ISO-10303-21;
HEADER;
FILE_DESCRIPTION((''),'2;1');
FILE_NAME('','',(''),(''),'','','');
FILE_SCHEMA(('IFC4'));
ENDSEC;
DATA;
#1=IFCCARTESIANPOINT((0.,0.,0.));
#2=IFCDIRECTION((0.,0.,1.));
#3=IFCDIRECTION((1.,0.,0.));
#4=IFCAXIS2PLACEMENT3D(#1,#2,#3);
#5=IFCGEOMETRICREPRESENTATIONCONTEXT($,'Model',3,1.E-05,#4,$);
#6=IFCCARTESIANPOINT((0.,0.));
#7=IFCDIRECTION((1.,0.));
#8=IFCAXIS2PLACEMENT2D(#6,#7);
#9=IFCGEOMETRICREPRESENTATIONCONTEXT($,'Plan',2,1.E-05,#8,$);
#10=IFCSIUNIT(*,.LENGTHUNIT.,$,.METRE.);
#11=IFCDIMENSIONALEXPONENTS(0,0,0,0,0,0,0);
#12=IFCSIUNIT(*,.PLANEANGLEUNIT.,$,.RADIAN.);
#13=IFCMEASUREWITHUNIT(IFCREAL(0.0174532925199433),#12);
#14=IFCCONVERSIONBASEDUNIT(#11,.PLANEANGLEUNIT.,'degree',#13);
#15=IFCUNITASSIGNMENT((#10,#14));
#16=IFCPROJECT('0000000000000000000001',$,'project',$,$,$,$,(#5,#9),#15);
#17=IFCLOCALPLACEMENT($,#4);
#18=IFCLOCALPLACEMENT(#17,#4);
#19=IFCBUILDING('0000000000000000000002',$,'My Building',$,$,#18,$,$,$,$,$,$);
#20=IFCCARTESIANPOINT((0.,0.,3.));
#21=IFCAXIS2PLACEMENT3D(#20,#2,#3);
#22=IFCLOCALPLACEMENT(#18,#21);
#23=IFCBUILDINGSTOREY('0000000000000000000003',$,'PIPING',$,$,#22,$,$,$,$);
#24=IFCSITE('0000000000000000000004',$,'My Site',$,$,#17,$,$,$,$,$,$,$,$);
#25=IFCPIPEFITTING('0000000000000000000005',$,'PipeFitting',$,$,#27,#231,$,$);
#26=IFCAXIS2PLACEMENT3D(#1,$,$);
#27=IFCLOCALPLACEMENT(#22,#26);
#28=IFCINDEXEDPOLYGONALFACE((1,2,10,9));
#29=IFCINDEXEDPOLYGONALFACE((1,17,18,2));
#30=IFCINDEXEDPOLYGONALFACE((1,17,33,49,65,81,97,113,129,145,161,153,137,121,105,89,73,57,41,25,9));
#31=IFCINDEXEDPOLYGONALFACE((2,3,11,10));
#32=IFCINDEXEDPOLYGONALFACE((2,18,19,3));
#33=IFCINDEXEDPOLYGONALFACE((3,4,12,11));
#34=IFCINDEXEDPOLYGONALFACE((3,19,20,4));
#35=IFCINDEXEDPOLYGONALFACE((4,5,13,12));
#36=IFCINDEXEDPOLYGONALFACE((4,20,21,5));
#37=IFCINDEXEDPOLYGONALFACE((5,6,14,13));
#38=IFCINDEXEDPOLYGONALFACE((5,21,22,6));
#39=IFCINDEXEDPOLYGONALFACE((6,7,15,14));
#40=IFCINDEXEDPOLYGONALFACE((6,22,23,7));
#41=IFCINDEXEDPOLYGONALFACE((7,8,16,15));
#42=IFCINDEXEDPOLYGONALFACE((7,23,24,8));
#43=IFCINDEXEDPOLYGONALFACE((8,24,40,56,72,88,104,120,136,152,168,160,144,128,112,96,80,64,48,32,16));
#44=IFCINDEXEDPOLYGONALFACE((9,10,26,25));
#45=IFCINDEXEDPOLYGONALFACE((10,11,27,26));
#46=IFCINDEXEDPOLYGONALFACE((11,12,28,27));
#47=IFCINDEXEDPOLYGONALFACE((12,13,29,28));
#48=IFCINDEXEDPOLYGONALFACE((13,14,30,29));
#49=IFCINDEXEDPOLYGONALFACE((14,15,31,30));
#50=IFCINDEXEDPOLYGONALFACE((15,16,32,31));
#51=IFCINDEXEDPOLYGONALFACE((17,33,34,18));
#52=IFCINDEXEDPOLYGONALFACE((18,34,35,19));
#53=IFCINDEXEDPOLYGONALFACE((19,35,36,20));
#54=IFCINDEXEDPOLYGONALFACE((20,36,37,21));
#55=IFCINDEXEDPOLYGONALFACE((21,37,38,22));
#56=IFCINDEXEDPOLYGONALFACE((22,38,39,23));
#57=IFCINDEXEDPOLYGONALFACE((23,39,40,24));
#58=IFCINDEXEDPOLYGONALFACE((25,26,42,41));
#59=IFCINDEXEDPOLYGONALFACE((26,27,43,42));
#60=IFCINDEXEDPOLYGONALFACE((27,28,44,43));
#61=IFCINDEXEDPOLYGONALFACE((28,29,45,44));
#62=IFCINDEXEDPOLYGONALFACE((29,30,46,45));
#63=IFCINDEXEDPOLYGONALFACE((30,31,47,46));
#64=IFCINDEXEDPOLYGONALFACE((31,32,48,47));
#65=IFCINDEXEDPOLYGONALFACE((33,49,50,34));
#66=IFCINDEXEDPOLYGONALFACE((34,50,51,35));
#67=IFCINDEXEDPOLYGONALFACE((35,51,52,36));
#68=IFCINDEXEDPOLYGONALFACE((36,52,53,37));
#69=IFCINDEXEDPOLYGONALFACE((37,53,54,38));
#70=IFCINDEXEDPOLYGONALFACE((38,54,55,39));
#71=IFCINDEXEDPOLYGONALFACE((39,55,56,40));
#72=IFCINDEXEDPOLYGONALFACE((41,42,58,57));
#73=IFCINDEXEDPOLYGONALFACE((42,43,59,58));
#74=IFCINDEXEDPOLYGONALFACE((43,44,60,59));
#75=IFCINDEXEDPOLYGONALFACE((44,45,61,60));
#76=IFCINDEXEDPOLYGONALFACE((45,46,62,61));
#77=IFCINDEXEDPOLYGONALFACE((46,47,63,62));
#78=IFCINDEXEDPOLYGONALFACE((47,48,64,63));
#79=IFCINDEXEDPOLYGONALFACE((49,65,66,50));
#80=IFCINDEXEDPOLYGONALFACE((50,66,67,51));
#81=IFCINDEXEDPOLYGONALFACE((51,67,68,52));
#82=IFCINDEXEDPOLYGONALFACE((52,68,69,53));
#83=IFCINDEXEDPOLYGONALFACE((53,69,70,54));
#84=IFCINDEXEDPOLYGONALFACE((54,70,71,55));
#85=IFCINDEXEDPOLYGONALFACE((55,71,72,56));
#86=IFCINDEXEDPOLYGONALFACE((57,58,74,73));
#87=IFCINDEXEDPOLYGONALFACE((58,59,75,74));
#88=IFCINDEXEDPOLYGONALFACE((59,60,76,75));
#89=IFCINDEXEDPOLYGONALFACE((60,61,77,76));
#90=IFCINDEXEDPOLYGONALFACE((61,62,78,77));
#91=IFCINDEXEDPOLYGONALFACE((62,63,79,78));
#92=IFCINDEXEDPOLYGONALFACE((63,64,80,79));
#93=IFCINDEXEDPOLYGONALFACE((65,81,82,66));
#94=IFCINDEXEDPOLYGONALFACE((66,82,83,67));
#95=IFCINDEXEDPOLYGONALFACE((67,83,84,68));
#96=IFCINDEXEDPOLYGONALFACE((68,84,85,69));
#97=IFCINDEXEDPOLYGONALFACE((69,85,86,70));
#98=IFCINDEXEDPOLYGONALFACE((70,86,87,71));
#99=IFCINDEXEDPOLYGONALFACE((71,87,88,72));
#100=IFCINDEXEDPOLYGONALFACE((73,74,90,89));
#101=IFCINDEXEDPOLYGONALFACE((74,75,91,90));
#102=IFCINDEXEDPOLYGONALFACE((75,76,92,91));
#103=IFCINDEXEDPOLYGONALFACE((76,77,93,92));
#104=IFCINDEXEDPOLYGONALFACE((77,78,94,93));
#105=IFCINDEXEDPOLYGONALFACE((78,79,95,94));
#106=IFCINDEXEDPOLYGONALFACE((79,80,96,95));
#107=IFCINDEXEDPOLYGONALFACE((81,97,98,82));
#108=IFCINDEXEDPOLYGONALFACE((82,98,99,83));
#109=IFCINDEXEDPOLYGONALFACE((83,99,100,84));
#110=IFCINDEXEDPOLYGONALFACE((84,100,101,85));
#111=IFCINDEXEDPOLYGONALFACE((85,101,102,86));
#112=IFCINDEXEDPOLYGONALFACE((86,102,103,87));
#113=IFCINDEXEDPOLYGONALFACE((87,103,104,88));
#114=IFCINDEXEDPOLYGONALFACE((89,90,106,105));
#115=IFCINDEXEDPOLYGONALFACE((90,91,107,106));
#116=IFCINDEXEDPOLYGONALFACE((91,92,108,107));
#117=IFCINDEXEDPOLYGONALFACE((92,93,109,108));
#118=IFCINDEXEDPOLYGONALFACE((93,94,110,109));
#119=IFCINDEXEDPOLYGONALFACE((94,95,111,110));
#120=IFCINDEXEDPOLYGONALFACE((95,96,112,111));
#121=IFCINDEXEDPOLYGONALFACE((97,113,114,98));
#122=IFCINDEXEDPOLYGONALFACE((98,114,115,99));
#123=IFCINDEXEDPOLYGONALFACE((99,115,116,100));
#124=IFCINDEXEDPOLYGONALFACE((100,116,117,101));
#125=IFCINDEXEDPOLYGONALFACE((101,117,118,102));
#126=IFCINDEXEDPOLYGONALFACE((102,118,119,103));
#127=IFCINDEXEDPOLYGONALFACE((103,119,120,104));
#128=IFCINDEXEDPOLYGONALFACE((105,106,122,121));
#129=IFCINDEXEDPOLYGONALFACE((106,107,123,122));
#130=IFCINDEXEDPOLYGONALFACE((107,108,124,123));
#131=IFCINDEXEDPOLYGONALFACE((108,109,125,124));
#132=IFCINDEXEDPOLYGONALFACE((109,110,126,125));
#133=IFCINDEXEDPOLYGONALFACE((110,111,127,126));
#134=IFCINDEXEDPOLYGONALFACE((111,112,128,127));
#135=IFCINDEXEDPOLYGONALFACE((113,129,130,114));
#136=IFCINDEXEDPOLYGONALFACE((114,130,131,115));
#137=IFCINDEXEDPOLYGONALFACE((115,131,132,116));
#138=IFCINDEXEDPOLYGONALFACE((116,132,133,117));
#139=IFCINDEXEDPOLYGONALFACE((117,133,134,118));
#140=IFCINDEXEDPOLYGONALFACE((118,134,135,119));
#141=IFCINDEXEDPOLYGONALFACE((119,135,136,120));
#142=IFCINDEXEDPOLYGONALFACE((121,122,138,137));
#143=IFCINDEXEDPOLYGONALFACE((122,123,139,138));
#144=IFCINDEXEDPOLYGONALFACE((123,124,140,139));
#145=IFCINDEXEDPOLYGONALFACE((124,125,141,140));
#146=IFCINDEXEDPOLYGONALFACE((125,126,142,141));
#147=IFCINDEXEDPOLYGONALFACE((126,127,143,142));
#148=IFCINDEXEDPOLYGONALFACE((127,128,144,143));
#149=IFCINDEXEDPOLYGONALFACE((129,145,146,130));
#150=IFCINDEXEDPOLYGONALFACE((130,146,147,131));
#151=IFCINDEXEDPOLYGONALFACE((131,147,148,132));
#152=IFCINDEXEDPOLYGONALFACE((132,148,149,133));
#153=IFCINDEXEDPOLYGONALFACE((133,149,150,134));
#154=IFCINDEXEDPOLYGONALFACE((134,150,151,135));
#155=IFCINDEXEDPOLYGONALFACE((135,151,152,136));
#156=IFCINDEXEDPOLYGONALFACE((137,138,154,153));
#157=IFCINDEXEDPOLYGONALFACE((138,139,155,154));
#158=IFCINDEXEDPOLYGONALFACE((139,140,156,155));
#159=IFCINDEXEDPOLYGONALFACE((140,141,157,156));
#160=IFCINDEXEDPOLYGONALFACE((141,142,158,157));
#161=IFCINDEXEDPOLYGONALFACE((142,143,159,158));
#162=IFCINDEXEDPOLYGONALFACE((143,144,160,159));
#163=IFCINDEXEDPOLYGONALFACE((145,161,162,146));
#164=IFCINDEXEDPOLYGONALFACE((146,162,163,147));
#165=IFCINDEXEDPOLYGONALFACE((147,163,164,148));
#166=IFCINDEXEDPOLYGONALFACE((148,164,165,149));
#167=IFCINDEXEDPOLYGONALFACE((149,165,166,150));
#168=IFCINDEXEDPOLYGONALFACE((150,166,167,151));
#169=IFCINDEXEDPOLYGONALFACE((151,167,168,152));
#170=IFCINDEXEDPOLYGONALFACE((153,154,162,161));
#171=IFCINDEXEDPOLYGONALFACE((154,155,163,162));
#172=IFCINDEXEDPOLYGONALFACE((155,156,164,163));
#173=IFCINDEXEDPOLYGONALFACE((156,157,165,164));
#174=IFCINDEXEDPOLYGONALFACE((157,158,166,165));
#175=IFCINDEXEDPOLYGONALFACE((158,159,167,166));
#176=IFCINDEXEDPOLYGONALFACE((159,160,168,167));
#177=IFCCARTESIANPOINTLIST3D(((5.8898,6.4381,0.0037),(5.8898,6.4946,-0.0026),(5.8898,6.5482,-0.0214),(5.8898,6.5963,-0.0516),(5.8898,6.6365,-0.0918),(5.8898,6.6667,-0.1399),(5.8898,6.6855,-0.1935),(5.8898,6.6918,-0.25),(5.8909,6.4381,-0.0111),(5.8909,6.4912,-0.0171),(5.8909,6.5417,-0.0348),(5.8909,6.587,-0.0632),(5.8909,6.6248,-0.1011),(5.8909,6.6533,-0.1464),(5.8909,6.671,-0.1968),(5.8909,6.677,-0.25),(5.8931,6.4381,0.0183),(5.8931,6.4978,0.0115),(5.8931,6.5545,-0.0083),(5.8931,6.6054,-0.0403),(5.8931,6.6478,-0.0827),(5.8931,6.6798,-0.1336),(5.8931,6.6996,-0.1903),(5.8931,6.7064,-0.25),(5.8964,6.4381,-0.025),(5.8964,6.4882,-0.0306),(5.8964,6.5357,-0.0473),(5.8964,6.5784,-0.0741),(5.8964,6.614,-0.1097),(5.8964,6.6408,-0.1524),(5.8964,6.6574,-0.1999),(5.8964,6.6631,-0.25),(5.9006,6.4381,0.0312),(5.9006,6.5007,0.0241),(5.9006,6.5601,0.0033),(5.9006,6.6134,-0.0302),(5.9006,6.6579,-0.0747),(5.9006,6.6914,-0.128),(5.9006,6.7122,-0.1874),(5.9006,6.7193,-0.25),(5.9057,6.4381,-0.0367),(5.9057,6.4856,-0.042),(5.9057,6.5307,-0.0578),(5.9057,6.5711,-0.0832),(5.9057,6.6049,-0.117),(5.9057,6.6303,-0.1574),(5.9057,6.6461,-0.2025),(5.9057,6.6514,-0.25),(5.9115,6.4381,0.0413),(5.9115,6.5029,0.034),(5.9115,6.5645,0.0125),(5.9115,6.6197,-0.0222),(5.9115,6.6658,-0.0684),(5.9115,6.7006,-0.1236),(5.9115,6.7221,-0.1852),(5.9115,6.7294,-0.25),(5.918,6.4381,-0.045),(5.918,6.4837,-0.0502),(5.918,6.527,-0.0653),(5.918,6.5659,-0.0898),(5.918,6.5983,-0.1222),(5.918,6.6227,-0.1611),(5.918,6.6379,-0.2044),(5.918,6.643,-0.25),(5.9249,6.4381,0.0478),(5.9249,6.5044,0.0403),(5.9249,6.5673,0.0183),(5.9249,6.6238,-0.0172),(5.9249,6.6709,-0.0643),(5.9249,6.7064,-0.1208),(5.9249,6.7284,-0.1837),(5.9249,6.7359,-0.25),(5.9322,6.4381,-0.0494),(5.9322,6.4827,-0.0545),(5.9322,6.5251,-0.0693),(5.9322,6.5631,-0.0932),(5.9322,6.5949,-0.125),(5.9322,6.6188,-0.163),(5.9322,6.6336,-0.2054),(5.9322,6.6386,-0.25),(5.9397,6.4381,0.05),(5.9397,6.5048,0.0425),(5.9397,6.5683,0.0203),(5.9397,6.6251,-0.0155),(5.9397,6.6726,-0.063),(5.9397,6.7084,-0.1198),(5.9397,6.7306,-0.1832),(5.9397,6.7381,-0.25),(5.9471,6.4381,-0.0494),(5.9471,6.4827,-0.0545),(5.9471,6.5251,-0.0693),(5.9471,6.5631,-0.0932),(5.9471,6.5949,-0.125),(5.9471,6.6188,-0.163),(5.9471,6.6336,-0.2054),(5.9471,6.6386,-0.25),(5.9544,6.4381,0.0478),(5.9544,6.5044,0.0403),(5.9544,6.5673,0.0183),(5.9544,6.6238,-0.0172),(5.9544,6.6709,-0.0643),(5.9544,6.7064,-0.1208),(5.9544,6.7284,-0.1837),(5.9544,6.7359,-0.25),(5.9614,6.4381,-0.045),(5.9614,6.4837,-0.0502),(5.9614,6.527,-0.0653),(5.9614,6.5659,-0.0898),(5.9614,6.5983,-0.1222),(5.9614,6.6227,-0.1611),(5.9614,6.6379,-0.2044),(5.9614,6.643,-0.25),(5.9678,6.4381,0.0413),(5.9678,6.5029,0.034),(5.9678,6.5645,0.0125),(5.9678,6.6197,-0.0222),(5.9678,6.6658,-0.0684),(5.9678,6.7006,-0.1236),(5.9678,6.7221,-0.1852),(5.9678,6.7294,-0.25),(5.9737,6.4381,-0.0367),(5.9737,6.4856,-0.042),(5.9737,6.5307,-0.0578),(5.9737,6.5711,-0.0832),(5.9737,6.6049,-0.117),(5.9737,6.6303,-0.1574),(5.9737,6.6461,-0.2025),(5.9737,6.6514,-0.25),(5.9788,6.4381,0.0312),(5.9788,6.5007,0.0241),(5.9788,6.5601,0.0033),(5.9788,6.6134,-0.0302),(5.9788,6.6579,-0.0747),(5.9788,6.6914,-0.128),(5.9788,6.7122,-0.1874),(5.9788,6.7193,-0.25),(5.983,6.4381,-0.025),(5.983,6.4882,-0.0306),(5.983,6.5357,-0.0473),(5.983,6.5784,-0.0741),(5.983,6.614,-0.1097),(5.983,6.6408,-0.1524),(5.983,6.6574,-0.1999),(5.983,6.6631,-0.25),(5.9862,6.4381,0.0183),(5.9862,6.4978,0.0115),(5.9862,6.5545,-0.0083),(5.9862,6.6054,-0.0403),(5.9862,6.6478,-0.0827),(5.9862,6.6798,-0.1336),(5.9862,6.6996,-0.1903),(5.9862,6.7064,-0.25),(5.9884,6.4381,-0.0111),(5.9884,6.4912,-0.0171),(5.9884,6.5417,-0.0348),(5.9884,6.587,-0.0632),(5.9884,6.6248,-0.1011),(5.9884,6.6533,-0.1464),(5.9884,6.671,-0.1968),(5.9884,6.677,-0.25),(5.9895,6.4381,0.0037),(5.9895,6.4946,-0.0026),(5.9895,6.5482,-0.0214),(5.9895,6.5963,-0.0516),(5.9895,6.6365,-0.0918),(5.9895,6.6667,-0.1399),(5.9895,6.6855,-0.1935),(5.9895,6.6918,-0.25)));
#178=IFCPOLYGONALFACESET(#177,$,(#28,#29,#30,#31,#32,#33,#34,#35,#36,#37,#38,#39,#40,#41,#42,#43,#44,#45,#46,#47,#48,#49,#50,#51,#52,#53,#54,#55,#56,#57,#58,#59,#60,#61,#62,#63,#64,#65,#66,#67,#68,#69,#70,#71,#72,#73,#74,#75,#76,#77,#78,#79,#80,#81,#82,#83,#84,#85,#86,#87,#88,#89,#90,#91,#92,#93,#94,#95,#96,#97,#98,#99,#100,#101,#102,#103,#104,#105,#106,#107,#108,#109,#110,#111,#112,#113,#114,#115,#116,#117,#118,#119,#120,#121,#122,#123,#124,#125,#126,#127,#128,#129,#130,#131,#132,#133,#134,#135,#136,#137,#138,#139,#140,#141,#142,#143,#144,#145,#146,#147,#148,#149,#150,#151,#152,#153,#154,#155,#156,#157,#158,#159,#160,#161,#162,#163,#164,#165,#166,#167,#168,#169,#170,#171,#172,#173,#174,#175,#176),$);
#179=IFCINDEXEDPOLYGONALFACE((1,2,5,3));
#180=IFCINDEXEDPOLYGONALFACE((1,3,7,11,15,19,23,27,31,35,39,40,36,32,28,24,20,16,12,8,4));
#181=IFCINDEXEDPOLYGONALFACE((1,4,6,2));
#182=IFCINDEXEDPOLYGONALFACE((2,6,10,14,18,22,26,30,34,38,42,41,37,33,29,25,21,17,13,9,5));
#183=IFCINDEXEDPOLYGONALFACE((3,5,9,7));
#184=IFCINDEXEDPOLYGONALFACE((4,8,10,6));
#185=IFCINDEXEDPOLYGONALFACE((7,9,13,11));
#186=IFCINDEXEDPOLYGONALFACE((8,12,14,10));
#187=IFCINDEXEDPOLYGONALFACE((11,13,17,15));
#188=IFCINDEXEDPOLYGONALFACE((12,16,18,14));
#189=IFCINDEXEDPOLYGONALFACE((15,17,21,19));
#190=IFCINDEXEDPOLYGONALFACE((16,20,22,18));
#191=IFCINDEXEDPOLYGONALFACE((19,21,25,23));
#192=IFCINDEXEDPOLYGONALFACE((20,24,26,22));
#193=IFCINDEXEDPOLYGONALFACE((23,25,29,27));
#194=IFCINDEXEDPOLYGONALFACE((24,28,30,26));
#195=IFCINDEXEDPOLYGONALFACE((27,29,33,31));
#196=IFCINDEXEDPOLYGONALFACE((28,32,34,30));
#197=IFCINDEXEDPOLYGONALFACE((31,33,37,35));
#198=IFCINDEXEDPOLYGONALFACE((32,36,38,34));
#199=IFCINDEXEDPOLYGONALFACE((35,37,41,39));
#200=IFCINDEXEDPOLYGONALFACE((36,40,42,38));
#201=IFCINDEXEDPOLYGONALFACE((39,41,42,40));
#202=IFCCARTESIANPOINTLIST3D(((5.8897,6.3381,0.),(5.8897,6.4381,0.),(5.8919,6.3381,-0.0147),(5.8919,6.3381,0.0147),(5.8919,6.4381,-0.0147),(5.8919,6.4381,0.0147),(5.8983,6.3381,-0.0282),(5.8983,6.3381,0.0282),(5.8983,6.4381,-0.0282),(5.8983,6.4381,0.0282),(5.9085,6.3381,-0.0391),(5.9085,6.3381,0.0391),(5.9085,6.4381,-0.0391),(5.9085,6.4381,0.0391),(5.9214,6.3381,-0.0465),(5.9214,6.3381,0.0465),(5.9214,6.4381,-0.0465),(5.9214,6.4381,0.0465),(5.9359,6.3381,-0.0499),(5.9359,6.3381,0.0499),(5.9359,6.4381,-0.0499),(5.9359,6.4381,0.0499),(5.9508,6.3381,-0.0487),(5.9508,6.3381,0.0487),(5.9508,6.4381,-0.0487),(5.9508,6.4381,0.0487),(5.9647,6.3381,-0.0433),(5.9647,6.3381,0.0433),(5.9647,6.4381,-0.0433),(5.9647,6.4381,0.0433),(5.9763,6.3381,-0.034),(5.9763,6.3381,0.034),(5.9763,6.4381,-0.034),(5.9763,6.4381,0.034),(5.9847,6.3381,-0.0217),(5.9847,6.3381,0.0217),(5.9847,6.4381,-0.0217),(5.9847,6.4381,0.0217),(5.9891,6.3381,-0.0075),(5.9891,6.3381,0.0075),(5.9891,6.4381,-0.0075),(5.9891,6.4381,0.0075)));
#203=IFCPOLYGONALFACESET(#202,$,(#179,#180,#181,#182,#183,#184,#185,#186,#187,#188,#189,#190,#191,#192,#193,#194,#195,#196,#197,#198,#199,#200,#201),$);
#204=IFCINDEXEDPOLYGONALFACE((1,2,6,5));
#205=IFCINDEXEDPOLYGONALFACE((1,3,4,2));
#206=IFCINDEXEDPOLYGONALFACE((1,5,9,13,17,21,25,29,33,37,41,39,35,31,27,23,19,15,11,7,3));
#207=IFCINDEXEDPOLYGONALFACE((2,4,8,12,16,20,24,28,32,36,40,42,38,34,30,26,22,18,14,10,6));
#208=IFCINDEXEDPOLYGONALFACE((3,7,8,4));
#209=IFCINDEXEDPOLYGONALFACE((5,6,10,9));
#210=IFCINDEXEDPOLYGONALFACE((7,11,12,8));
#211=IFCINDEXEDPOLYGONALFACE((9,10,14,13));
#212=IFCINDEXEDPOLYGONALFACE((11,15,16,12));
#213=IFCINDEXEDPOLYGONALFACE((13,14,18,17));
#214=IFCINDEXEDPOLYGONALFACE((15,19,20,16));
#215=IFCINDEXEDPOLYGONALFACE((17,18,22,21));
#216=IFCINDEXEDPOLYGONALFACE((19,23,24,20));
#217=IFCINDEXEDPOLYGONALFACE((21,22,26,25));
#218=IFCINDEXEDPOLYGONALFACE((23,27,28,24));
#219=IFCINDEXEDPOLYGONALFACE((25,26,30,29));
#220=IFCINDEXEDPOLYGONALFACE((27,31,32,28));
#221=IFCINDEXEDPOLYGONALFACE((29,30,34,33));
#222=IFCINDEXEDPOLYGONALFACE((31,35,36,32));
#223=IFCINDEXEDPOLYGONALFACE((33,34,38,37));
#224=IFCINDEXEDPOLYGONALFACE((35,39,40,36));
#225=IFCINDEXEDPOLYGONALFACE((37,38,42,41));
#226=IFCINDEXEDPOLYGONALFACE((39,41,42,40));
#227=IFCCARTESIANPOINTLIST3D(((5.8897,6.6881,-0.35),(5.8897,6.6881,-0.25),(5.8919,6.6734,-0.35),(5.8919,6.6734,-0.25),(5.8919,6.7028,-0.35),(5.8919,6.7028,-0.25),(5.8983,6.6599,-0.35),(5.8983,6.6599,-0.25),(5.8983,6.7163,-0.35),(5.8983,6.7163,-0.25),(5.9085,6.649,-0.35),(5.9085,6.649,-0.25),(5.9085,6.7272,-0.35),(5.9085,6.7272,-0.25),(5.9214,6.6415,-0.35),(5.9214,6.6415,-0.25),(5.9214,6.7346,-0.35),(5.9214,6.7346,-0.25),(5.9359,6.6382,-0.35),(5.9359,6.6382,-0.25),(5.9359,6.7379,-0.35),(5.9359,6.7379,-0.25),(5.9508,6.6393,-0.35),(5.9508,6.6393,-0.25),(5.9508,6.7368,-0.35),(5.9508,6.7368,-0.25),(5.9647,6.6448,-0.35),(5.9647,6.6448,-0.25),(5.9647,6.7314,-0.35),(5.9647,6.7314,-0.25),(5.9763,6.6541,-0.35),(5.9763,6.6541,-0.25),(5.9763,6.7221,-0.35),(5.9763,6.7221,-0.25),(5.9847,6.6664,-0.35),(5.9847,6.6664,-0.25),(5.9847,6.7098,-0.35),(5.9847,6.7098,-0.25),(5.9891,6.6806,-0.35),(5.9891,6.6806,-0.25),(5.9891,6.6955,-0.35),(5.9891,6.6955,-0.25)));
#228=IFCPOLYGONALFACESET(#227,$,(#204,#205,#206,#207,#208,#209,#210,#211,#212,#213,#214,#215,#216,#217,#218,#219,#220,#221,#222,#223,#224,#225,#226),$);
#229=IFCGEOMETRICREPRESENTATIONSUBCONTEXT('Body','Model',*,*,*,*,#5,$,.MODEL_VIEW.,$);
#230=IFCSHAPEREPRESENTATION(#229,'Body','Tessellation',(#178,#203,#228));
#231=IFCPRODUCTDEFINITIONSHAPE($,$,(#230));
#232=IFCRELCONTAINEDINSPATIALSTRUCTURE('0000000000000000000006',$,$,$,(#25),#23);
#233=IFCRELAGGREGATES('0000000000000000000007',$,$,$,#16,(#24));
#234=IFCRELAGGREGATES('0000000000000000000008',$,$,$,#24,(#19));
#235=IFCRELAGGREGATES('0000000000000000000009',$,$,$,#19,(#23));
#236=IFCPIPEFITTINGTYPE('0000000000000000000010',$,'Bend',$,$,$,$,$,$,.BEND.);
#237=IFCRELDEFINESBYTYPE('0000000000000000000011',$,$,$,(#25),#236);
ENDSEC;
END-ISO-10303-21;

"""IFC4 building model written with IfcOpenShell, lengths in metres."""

from ifc_helpers import new_model, entity, si_unit, converted_unit, frame, origin_with_axes, origin_2d_with_axis, place, context, subcontext, project, spatial, circle, extrude, source, transform, mapped, type_object, type_shapes, element, save


model = new_model("IFC4")

# Units and contexts
model_context = context("Model", 3, precision=1e-05, world=origin_with_axes())
plan_context = context("Plan", 2, precision=1e-05, world=origin_2d_with_axis())
body_context = subcontext(model_context, "Body", "Model", "MODEL_VIEW")
ifc_project = project(units=[si_unit("LENGTHUNIT", "METRE"), converted_unit("PLANEANGLEUNIT", "degree", entity("IfcReal", 0.0174532925199433), si_unit("PLANEANGLEUNIT", "RADIAN"), dimensions=[0, 0, 0, 0, 0, 0, 0])], contexts=[model_context, plan_context])

# Site, building, storey
site_placement = place(None, origin_with_axes())
site = spatial("IfcSite", under=ifc_project, at=site_placement, Name="My Site")
building_placement = place(site_placement, origin_with_axes())
building = spatial("IfcBuilding", under=site, at=building_placement, Name="My Building")
storey_placement = place(building_placement, frame((0.0, 0.0, 3.0), z_axis=(0.0, 0.0, 1.0), x_axis=(1.0, 0.0, 0.0)))
storey = spatial("IfcBuildingStorey", under=building, at=storey_placement, Name="PIPING")

# Pipe fitting
pipe_fitting_type = type_object("IfcPipeFittingType", Name="Bend", PredefinedType="BEND")
shared_shape = source(origin_with_axes(), body_context, "Body", "SolidModel", [
    entity("IfcSweptDiskSolid", entity("IfcIndexedPolyCurve", entity("IfcCartesianPointList3D", [[0.0, 0.0, 0.1], [0.0, -0.0732, 0.2768], [0.0, -0.25, 0.35]]), [entity("IfcArcIndex", [1, 2, 3])]), 0.05),
    extrude(circle(Radius=0.05), origin_with_axes(), (0.0, 0.0, 1.0), 0.1),
    extrude(circle(Radius=0.05), frame((0.0, -0.25, 0.35), z_axis=(0.0, -1.0, 0.0), x_axis=(1.0, 0.0, 0.0)), (0.0, 0.0, 1.0), 0.1),
])
type_shapes(pipe_fitting_type, [shared_shape])
for number, where, z_axis, x_axis, name in (
    (1, (5.9397, 6.3381, 0.0), (0.0, 1.0, 0.0), (-1.0, 0.0, 0.0), "PipeFitting"),
):
    element("IfcPipeFitting", number, at=place(storey_placement, frame(where, z_axis=z_axis, x_axis=x_axis)), inside=storey, type_object=pipe_fitting_type, Name=name, context=body_context, shape_type="MappedRepresentation", body=[
        mapped(shared_shape, transform((0.0, 0.0, 0.0), x_axis=(1.0, 0.0, 0.0), y_axis=(0.0, 1.0, 0.0), z_axis=(0.0, 0.0, 1.0), scale=1.0)),
    ])

save(model, "model.ifc")
